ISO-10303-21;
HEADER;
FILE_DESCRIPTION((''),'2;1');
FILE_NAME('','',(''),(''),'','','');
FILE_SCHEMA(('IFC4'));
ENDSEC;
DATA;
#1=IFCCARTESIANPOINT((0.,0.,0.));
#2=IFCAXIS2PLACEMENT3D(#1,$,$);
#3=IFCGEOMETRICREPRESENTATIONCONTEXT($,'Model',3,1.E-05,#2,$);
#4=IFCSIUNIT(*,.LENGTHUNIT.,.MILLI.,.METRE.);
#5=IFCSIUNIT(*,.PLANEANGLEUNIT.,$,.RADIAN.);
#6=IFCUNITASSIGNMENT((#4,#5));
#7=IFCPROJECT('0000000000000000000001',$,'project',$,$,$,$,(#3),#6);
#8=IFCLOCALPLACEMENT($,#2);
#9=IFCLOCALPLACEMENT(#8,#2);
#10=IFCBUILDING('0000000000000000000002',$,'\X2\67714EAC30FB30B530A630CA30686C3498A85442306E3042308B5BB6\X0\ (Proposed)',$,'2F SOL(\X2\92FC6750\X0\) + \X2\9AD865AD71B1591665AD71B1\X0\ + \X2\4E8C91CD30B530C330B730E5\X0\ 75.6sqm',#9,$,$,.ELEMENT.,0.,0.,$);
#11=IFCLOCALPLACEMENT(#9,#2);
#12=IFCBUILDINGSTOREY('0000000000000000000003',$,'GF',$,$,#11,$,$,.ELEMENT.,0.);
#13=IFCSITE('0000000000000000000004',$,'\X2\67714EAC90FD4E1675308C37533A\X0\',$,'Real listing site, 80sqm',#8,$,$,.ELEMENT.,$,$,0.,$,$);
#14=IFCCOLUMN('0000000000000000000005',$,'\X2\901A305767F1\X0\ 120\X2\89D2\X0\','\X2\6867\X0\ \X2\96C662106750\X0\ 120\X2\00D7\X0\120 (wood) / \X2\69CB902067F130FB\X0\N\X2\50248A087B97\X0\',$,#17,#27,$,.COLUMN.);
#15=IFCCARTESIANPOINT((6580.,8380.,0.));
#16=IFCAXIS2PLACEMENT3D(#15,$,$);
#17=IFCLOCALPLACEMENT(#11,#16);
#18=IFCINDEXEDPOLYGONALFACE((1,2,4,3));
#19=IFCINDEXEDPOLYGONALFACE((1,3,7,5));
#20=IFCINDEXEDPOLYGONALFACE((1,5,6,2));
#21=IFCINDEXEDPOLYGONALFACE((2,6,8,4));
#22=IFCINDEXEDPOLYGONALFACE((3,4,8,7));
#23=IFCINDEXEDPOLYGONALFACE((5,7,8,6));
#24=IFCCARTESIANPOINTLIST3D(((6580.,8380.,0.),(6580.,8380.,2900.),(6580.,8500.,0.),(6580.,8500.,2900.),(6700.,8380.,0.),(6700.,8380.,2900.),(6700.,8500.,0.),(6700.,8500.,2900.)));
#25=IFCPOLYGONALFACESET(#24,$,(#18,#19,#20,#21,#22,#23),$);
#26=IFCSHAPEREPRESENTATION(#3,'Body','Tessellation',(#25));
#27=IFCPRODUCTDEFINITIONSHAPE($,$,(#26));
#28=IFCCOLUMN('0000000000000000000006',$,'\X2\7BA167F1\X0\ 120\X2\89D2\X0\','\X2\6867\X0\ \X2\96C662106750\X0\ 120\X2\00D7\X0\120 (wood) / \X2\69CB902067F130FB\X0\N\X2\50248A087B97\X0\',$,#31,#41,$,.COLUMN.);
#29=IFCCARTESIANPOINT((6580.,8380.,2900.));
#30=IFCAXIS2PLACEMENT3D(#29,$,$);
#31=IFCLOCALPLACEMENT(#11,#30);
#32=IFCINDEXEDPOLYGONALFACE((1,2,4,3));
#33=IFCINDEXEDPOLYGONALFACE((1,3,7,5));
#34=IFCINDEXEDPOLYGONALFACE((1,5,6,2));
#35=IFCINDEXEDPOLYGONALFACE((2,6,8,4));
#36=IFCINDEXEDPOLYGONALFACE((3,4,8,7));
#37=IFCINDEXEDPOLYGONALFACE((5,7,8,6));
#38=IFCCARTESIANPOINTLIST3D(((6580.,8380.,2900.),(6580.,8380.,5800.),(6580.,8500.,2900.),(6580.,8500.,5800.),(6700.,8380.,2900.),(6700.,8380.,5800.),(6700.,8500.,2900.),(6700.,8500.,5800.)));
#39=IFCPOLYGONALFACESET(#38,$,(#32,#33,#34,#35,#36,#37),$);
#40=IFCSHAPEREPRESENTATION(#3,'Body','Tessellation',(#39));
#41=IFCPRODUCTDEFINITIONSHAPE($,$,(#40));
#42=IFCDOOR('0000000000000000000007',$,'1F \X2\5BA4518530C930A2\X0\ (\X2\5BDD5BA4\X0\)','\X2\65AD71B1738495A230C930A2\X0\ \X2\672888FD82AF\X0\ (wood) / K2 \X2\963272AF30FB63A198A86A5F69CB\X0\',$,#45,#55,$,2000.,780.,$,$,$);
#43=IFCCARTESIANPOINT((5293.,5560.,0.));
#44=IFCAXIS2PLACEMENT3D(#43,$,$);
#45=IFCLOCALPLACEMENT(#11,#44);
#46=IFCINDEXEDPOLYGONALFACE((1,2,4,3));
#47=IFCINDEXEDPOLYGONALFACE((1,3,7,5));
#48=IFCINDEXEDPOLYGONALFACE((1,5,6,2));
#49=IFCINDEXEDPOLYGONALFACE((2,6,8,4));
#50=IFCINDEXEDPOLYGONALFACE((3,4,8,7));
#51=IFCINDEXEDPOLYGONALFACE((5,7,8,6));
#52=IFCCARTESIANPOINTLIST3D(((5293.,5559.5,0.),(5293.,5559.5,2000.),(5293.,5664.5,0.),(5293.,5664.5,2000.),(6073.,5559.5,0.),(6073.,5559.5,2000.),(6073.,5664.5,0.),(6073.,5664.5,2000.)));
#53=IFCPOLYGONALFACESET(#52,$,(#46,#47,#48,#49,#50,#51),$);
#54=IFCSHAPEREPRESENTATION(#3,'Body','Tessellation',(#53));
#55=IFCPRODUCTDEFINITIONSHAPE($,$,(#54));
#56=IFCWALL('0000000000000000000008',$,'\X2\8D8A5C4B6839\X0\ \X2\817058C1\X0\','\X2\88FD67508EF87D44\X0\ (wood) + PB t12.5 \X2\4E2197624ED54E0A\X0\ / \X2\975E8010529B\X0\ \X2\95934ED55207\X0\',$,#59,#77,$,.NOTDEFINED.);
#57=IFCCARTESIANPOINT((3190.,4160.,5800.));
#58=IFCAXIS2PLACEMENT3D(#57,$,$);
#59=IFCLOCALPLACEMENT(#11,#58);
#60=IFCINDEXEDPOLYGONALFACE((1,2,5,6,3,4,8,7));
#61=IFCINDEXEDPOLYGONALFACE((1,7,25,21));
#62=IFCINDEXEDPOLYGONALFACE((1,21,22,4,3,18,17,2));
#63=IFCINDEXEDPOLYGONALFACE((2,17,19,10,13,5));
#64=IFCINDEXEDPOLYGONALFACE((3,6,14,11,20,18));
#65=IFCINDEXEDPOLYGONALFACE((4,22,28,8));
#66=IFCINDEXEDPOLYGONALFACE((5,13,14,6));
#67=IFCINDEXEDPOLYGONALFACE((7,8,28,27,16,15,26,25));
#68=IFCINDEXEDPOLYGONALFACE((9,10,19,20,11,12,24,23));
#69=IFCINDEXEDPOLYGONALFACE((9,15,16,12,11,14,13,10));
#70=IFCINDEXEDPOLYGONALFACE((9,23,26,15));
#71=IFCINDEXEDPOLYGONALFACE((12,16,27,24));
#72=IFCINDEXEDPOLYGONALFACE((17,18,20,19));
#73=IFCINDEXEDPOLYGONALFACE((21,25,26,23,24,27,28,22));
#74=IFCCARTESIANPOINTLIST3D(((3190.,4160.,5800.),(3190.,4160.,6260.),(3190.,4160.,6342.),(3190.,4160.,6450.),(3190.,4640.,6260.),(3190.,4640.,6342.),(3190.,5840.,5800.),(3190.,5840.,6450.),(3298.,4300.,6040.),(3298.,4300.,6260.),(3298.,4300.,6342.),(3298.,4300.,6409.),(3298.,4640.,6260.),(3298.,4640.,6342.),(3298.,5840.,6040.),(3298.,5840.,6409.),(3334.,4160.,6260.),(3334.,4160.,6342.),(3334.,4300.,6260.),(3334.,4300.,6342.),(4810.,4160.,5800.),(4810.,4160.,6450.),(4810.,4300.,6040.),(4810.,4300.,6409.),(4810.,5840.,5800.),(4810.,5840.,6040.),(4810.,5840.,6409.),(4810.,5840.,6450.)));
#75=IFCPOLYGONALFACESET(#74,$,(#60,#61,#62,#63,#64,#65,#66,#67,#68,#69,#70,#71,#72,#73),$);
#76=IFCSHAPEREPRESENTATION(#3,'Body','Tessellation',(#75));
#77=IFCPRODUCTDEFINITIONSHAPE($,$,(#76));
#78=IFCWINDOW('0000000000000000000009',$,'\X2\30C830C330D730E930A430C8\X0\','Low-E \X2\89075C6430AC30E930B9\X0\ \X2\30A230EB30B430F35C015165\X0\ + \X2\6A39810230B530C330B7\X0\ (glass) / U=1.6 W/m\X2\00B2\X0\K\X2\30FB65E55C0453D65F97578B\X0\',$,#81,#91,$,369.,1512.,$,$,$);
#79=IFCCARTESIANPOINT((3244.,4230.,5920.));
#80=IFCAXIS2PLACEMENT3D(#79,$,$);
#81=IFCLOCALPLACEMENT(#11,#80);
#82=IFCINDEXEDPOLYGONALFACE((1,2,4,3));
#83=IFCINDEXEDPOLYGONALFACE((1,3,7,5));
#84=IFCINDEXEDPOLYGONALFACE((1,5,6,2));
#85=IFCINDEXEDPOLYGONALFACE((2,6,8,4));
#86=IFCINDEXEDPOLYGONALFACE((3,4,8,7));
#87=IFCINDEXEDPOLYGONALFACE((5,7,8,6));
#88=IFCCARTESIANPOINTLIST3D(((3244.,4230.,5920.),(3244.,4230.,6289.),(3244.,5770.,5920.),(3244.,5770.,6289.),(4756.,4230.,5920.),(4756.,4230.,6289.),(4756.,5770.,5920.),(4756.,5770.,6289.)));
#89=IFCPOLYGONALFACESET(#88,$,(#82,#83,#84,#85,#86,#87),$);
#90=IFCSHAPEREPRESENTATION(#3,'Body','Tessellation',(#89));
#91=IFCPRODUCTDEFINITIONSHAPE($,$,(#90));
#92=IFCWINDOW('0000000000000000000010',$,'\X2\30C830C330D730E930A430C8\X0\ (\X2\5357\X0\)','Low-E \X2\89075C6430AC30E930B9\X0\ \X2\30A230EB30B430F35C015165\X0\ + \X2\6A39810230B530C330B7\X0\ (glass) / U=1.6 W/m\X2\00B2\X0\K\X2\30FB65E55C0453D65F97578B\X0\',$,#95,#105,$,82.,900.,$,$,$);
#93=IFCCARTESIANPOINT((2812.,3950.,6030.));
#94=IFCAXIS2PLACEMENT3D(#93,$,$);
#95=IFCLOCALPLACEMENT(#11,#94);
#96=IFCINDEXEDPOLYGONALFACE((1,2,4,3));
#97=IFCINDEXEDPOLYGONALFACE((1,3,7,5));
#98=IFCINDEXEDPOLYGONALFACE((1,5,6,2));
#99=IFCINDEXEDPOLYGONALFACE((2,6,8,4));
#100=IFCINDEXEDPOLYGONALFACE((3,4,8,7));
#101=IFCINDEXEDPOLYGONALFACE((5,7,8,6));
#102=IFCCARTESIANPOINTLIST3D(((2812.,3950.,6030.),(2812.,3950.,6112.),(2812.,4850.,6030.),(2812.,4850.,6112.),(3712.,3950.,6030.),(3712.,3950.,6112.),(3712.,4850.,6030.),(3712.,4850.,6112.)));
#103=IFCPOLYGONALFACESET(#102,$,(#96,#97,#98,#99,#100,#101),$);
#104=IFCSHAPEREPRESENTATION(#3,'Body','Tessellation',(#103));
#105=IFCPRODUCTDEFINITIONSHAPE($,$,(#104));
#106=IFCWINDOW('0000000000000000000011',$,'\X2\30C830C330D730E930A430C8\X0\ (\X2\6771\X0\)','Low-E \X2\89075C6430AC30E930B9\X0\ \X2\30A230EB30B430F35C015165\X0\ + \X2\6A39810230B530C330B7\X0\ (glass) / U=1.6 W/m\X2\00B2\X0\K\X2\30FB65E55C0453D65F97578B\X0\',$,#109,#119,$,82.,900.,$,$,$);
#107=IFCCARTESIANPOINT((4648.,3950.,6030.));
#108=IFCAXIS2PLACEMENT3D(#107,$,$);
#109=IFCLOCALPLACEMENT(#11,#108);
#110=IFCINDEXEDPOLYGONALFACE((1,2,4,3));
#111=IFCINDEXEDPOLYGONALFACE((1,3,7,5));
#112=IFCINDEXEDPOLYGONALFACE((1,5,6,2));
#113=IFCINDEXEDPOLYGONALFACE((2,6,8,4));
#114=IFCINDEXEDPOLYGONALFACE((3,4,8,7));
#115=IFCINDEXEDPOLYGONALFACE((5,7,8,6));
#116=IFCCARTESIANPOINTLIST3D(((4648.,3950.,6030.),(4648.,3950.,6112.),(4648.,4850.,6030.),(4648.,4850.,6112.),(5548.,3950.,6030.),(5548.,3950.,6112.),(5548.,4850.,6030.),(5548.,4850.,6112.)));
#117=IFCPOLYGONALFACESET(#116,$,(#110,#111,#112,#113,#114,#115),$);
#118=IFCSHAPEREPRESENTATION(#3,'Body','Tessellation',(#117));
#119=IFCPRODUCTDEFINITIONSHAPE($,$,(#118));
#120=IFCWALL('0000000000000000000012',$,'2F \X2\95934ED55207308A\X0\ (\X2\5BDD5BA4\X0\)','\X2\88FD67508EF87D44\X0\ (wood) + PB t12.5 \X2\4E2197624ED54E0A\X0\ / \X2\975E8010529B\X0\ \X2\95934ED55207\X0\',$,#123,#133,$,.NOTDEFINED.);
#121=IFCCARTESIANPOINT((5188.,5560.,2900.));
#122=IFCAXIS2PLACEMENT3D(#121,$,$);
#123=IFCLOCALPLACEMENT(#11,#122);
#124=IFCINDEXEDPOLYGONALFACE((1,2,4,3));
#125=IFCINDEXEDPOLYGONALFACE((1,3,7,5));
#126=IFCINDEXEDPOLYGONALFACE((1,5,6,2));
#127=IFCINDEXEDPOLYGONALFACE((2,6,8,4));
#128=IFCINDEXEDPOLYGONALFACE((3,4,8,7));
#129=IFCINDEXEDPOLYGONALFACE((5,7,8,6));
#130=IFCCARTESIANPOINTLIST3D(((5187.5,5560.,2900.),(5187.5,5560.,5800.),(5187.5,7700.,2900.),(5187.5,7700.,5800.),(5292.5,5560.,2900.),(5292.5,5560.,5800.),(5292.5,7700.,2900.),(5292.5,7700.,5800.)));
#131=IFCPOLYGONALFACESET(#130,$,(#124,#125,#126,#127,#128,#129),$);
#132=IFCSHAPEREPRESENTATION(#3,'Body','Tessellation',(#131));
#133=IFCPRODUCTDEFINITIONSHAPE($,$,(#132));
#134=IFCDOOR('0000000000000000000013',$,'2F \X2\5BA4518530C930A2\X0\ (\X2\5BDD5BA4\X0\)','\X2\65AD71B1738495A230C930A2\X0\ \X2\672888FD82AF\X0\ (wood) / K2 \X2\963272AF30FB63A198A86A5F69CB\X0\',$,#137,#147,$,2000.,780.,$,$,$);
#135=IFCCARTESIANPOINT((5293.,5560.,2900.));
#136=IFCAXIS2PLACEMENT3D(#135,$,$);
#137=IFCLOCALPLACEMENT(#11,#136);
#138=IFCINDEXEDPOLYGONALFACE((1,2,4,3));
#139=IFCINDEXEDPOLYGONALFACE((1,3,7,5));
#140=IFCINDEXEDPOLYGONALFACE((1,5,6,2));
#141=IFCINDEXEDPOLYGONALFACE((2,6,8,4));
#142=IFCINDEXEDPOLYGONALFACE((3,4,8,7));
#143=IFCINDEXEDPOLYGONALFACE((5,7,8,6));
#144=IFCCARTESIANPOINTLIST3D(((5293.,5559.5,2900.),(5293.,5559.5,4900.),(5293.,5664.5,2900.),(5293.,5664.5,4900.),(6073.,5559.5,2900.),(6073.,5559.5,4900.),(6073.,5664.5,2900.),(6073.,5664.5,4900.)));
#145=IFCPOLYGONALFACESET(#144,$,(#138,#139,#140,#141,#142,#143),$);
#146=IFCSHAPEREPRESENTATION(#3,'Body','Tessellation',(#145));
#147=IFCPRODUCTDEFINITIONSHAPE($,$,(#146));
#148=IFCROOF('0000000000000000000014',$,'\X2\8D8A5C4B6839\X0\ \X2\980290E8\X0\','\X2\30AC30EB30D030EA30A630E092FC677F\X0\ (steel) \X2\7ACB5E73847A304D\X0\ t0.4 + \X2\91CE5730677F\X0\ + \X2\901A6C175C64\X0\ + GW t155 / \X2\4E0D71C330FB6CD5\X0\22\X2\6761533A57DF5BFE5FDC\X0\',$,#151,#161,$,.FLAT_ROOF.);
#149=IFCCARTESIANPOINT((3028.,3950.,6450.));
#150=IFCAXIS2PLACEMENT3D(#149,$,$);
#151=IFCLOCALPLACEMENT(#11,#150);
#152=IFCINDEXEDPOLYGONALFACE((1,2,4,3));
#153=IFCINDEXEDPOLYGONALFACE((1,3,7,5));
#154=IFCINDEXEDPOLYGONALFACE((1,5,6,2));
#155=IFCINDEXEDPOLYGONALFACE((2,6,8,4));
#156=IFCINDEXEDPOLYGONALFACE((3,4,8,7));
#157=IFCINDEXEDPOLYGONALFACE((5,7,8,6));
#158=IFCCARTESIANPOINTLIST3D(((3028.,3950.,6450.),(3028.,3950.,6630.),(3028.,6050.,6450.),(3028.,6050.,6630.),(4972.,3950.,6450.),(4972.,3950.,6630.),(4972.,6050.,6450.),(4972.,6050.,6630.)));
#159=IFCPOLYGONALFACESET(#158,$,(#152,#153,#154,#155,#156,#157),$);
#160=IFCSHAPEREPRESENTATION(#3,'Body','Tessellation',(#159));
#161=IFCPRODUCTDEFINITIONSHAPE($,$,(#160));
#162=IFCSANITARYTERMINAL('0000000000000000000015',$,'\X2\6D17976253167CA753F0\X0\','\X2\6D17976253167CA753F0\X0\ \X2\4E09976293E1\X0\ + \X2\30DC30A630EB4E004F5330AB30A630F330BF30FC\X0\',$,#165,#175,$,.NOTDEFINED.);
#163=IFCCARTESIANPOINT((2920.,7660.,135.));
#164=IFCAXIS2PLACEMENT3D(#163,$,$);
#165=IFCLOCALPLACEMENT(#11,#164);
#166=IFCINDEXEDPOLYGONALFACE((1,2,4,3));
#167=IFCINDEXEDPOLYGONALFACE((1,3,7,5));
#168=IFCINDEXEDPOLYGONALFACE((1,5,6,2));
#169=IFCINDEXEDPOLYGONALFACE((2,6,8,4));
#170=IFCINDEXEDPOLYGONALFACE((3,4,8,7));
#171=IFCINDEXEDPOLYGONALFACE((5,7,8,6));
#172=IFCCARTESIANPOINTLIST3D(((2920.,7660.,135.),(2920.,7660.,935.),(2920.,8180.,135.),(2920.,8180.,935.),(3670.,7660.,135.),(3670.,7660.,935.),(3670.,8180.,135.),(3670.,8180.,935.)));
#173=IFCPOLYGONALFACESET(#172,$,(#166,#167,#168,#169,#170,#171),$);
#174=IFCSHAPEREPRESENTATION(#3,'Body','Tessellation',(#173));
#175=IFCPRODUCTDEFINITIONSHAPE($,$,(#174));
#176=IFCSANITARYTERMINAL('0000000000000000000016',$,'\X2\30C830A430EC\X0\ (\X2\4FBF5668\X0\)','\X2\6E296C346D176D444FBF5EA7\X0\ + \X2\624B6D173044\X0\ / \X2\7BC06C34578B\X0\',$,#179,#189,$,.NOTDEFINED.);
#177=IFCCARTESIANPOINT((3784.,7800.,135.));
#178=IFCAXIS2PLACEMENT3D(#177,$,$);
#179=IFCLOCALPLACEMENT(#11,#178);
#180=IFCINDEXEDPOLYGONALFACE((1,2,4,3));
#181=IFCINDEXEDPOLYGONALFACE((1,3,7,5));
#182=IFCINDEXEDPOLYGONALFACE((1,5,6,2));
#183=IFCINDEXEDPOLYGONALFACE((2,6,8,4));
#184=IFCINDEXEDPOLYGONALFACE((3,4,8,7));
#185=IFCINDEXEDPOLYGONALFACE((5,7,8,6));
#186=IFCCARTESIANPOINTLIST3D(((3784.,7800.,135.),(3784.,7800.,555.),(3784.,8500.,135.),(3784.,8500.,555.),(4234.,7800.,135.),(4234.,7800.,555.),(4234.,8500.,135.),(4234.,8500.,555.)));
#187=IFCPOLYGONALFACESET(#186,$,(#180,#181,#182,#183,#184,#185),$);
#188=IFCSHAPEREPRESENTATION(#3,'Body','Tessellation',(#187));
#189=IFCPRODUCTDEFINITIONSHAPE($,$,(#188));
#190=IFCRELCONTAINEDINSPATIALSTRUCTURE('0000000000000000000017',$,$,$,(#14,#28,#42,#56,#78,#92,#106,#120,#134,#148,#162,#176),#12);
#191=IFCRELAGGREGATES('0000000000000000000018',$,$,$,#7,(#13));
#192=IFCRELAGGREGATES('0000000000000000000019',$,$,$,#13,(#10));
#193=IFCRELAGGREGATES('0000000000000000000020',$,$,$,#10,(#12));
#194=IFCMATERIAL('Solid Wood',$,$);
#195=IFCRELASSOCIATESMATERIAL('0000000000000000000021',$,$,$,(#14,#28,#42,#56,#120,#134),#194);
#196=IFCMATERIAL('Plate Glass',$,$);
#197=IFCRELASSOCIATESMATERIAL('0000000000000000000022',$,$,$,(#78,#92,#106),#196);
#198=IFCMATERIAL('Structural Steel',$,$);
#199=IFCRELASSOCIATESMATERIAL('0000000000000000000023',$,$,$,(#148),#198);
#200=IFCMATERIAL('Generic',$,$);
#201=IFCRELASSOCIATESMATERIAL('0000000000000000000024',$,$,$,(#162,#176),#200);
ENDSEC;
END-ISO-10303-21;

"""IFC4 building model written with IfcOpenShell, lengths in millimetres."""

from ifc_helpers import new_model, si_unit, frame, frame_2d, origin, place, context, project, spatial, rectangle, extrude, material, element, fill, save


model = new_model("IFC4")

# Units and contexts
model_context = context("Model", 3, precision=1e-05, world=origin())
ifc_project = project(units=[si_unit("LENGTHUNIT", "METRE", prefix="MILLI"), si_unit("PLANEANGLEUNIT", "RADIAN")], contexts=[model_context])

# Site, building, storey
site_placement = place(None, origin())
site = spatial("IfcSite", under=ifc_project, at=site_placement, Name="東京都世田谷区", ObjectType="Real listing site, 80sqm", CompositionType="ELEMENT", RefElevation=0.0)
building_placement = place(site_placement, origin())
building = spatial("IfcBuilding", under=site, at=building_placement, Name="東京・サウナと水風呂のある家 (Proposed)", ObjectType="2F SOL(鋼材) + 高断熱外断熱 + 二重サッシュ 75.6sqm", CompositionType="ELEMENT", ElevationOfRefHeight=0.0, ElevationOfTerrain=0.0)
storey_placement = place(building_placement, origin())
storey = spatial("IfcBuildingStorey", under=building, at=storey_placement, Name="GF", CompositionType="ELEMENT", Elevation=0.0)

# Columns
ifc_material_1 = material(Name="Solid Wood")
column_1_placement = place(storey_placement, frame((6580.0, 8380.0, 0.0)))
element("IfcColumn", 1, at=column_1_placement, inside=storey, material=ifc_material_1, Name="通し柱 120角", Description="桧 集成材 120×120 (wood) / 構造柱・N値計算", PredefinedType="COLUMN", context=model_context, shape_type="SweptSolid", body=[
    extrude(rectangle(XDim=120.0, YDim=120.0, at=frame_2d((60.0, 60.0))), frame((6580.0, 8380.0, 0.0)), (0.0, 0.0, 1.0), 2900.0),
])
column_2_placement = place(storey_placement, frame((6580.0, 8380.0, 2900.0)))
element("IfcColumn", 2, at=column_2_placement, inside=storey, material=ifc_material_1, Name="管柱 120角", Description="桧 集成材 120×120 (wood) / 構造柱・N値計算", PredefinedType="COLUMN", context=model_context, shape_type="SweptSolid", body=[
    extrude(rectangle(XDim=120.0, YDim=120.0, at=frame_2d((60.0, 60.0))), frame((6580.0, 8380.0, 2900.0)), (0.0, 0.0, 1.0), 2900.0),
])

# Door
door_1_placement = place(storey_placement, frame((5293.0, 5560.0, 0.0)))
element("IfcDoor", 3, at=door_1_placement, inside=storey, material=ifc_material_1, Name="1F 室内ドア (寝室)", Description="断熱玄関ドア 木製芯 (wood) / K2 防犯・採風機構", OverallHeight=2000.0, OverallWidth=780.0, context=model_context, shape_type="SweptSolid", body=[
    extrude(rectangle(XDim=780.0, YDim=105.0, at=frame_2d((390.0, 52.0))), frame((5293.0, 5560.0, 0.0)), (0.0, 0.0, 1.0), 2000.0),
])

# Wall, openings, windows
wall_1_placement = place(storey_placement, frame((3190.0, 4160.0, 5800.0)))
wall_1 = element("IfcWall", 4, at=wall_1_placement, inside=storey, material=ifc_material_1, Name="越屋根 腰壁", Description="製材軸組 (wood) + PB t12.5 両面仕上 / 非耐力 間仕切", PredefinedType="NOTDEFINED", context=model_context, shape_type="SweptSolid", body=[
    extrude(rectangle(XDim=1620.0, YDim=1680.0, at=frame_2d((810.0, 840.0))), frame((3190.0, 4160.0, 5800.0)), (0.0, 0.0, 1.0), 650.0),
])
opening_1_placement = place(storey_placement, frame((3244.0, 4230.0, 5920.0)))
opening_1 = element("IfcOpeningElement", 5, at=opening_1_placement, cuts=wall_1, PredefinedType="NOTDEFINED", context=model_context, shape_type="SweptSolid", body=[
    extrude(rectangle(XDim=1512.0, YDim=1540.0, at=frame_2d((756.0, 770.0))), frame((3244.0, 4230.0, 5920.0)), (0.0, 0.0, 1.0), 369.0),
])
opening_2_placement = place(storey_placement, frame((2812.0, 3950.0, 6030.0)))
opening_2 = element("IfcOpeningElement", 6, at=opening_2_placement, cuts=wall_1, PredefinedType="NOTDEFINED", context=model_context, shape_type="SweptSolid", body=[
    extrude(rectangle(XDim=900.0, YDim=900.0, at=frame_2d((450.0, 450.0))), frame((2812.0, 3950.0, 6030.0)), (0.0, 0.0, 1.0), 82.0),
])
opening_3_placement = place(storey_placement, frame((4648.0, 3950.0, 6030.0)))
opening_3 = element("IfcOpeningElement", 7, at=opening_3_placement, cuts=wall_1, PredefinedType="NOTDEFINED", context=model_context, shape_type="SweptSolid", body=[
    extrude(rectangle(XDim=900.0, YDim=900.0, at=frame_2d((450.0, 450.0))), frame((4648.0, 3950.0, 6030.0)), (0.0, 0.0, 1.0), 82.0),
])
ifc_material_2 = material(Name="Plate Glass")
window_1_placement = place(storey_placement, frame((3244.0, 4230.0, 5920.0)))
window_1 = element("IfcWindow", 8, at=window_1_placement, inside=storey, material=ifc_material_2, Name="トップライト", Description="Low-E 複層ガラス アルゴン封入 + 樹脂サッシ (glass) / U=1.6 W/m²K・日射取得型", OverallHeight=369.0, OverallWidth=1512.0, context=model_context, shape_type="SweptSolid", body=[
    extrude(rectangle(XDim=1512.0, YDim=1540.0, at=frame_2d((756.0, 770.0))), frame((3244.0, 4230.0, 5920.0)), (0.0, 0.0, 1.0), 369.0),
])
fill(opening_1, window_1)
window_2_placement = place(storey_placement, frame((2812.0, 3950.0, 6030.0)))
window_2 = element("IfcWindow", 9, at=window_2_placement, inside=storey, material=ifc_material_2, Name="トップライト (南)", Description="Low-E 複層ガラス アルゴン封入 + 樹脂サッシ (glass) / U=1.6 W/m²K・日射取得型", OverallHeight=82.0, OverallWidth=900.0, context=model_context, shape_type="SweptSolid", body=[
    extrude(rectangle(XDim=900.0, YDim=900.0, at=frame_2d((450.0, 450.0))), frame((2812.0, 3950.0, 6030.0)), (0.0, 0.0, 1.0), 82.0),
])
fill(opening_2, window_2)
window_3_placement = place(storey_placement, frame((4648.0, 3950.0, 6030.0)))
window_3 = element("IfcWindow", 10, at=window_3_placement, inside=storey, material=ifc_material_2, Name="トップライト (東)", Description="Low-E 複層ガラス アルゴン封入 + 樹脂サッシ (glass) / U=1.6 W/m²K・日射取得型", OverallHeight=82.0, OverallWidth=900.0, context=model_context, shape_type="SweptSolid", body=[
    extrude(rectangle(XDim=900.0, YDim=900.0, at=frame_2d((450.0, 450.0))), frame((4648.0, 3950.0, 6030.0)), (0.0, 0.0, 1.0), 82.0),
])
fill(opening_3, window_3)

# Wall
wall_2_placement = place(storey_placement, frame((5188.0, 5560.0, 2900.0)))
element("IfcWall", 11, at=wall_2_placement, inside=storey, material=ifc_material_1, Name="2F 間仕切り (寝室)", Description="製材軸組 (wood) + PB t12.5 両面仕上 / 非耐力 間仕切", PredefinedType="NOTDEFINED", context=model_context, shape_type="SweptSolid", body=[
    extrude(rectangle(XDim=105.0, YDim=2140.0, at=frame_2d((52.0, 1070.0))), frame((5188.0, 5560.0, 2900.0)), (0.0, 0.0, 1.0), 2900.0),
])

# Door
door_2_placement = place(storey_placement, frame((5293.0, 5560.0, 2900.0)))
element("IfcDoor", 12, at=door_2_placement, inside=storey, material=ifc_material_1, Name="2F 室内ドア (寝室)", Description="断熱玄関ドア 木製芯 (wood) / K2 防犯・採風機構", OverallHeight=2000.0, OverallWidth=780.0, context=model_context, shape_type="SweptSolid", body=[
    extrude(rectangle(XDim=780.0, YDim=105.0, at=frame_2d((390.0, 52.0))), frame((5293.0, 5560.0, 2900.0)), (0.0, 0.0, 1.0), 2000.0),
])

# Roof
ifc_material_3 = material(Name="Structural Steel")
roof_placement = place(storey_placement, frame((3028.0, 3950.0, 6450.0)))
element("IfcRoof", 13, at=roof_placement, inside=storey, material=ifc_material_3, Name="越屋根 頂部", Description="ガルバリウム鋼板 (steel) 立平葺き t0.4 + 野地板 + 通気層 + GW t155 / 不燃・法22条区域対応", PredefinedType="FLAT_ROOF", context=model_context, shape_type="SweptSolid", body=[
    extrude(rectangle(XDim=1944.0, YDim=2100.0, at=frame_2d((972.0, 1050.0))), frame((3028.0, 3950.0, 6450.0)), (0.0, 0.0, 1.0), 180.0),
])

# Sanitary terminals
ifc_material_4 = material(Name="Generic")
sanitary_terminal_1_placement = place(storey_placement, frame((2920.0, 7660.0, 135.0)))
element("IfcSanitaryTerminal", 14, at=sanitary_terminal_1_placement, inside=storey, material=ifc_material_4, Name="洗面化粧台", Description="洗面化粧台 三面鏡 + ボウル一体カウンター", PredefinedType="NOTDEFINED", context=model_context, shape_type="SweptSolid", body=[
    extrude(rectangle(XDim=750.0, YDim=520.0, at=frame_2d((375.0, 260.0))), frame((2920.0, 7660.0, 135.0)), (0.0, 0.0, 1.0), 800.0),
])
sanitary_terminal_2_placement = place(storey_placement, frame((3784.0, 7800.0, 135.0)))
element("IfcSanitaryTerminal", 15, at=sanitary_terminal_2_placement, inside=storey, material=ifc_material_4, Name="トイレ (便器)", Description="温水洗浄便座 + 手洗い / 節水型", PredefinedType="NOTDEFINED", context=model_context, shape_type="SweptSolid", body=[
    extrude(rectangle(XDim=450.0, YDim=700.0, at=frame_2d((225.0, 350.0))), frame((3784.0, 7800.0, 135.0)), (0.0, 0.0, 1.0), 420.0),
])

save(model, "model.ifc")
